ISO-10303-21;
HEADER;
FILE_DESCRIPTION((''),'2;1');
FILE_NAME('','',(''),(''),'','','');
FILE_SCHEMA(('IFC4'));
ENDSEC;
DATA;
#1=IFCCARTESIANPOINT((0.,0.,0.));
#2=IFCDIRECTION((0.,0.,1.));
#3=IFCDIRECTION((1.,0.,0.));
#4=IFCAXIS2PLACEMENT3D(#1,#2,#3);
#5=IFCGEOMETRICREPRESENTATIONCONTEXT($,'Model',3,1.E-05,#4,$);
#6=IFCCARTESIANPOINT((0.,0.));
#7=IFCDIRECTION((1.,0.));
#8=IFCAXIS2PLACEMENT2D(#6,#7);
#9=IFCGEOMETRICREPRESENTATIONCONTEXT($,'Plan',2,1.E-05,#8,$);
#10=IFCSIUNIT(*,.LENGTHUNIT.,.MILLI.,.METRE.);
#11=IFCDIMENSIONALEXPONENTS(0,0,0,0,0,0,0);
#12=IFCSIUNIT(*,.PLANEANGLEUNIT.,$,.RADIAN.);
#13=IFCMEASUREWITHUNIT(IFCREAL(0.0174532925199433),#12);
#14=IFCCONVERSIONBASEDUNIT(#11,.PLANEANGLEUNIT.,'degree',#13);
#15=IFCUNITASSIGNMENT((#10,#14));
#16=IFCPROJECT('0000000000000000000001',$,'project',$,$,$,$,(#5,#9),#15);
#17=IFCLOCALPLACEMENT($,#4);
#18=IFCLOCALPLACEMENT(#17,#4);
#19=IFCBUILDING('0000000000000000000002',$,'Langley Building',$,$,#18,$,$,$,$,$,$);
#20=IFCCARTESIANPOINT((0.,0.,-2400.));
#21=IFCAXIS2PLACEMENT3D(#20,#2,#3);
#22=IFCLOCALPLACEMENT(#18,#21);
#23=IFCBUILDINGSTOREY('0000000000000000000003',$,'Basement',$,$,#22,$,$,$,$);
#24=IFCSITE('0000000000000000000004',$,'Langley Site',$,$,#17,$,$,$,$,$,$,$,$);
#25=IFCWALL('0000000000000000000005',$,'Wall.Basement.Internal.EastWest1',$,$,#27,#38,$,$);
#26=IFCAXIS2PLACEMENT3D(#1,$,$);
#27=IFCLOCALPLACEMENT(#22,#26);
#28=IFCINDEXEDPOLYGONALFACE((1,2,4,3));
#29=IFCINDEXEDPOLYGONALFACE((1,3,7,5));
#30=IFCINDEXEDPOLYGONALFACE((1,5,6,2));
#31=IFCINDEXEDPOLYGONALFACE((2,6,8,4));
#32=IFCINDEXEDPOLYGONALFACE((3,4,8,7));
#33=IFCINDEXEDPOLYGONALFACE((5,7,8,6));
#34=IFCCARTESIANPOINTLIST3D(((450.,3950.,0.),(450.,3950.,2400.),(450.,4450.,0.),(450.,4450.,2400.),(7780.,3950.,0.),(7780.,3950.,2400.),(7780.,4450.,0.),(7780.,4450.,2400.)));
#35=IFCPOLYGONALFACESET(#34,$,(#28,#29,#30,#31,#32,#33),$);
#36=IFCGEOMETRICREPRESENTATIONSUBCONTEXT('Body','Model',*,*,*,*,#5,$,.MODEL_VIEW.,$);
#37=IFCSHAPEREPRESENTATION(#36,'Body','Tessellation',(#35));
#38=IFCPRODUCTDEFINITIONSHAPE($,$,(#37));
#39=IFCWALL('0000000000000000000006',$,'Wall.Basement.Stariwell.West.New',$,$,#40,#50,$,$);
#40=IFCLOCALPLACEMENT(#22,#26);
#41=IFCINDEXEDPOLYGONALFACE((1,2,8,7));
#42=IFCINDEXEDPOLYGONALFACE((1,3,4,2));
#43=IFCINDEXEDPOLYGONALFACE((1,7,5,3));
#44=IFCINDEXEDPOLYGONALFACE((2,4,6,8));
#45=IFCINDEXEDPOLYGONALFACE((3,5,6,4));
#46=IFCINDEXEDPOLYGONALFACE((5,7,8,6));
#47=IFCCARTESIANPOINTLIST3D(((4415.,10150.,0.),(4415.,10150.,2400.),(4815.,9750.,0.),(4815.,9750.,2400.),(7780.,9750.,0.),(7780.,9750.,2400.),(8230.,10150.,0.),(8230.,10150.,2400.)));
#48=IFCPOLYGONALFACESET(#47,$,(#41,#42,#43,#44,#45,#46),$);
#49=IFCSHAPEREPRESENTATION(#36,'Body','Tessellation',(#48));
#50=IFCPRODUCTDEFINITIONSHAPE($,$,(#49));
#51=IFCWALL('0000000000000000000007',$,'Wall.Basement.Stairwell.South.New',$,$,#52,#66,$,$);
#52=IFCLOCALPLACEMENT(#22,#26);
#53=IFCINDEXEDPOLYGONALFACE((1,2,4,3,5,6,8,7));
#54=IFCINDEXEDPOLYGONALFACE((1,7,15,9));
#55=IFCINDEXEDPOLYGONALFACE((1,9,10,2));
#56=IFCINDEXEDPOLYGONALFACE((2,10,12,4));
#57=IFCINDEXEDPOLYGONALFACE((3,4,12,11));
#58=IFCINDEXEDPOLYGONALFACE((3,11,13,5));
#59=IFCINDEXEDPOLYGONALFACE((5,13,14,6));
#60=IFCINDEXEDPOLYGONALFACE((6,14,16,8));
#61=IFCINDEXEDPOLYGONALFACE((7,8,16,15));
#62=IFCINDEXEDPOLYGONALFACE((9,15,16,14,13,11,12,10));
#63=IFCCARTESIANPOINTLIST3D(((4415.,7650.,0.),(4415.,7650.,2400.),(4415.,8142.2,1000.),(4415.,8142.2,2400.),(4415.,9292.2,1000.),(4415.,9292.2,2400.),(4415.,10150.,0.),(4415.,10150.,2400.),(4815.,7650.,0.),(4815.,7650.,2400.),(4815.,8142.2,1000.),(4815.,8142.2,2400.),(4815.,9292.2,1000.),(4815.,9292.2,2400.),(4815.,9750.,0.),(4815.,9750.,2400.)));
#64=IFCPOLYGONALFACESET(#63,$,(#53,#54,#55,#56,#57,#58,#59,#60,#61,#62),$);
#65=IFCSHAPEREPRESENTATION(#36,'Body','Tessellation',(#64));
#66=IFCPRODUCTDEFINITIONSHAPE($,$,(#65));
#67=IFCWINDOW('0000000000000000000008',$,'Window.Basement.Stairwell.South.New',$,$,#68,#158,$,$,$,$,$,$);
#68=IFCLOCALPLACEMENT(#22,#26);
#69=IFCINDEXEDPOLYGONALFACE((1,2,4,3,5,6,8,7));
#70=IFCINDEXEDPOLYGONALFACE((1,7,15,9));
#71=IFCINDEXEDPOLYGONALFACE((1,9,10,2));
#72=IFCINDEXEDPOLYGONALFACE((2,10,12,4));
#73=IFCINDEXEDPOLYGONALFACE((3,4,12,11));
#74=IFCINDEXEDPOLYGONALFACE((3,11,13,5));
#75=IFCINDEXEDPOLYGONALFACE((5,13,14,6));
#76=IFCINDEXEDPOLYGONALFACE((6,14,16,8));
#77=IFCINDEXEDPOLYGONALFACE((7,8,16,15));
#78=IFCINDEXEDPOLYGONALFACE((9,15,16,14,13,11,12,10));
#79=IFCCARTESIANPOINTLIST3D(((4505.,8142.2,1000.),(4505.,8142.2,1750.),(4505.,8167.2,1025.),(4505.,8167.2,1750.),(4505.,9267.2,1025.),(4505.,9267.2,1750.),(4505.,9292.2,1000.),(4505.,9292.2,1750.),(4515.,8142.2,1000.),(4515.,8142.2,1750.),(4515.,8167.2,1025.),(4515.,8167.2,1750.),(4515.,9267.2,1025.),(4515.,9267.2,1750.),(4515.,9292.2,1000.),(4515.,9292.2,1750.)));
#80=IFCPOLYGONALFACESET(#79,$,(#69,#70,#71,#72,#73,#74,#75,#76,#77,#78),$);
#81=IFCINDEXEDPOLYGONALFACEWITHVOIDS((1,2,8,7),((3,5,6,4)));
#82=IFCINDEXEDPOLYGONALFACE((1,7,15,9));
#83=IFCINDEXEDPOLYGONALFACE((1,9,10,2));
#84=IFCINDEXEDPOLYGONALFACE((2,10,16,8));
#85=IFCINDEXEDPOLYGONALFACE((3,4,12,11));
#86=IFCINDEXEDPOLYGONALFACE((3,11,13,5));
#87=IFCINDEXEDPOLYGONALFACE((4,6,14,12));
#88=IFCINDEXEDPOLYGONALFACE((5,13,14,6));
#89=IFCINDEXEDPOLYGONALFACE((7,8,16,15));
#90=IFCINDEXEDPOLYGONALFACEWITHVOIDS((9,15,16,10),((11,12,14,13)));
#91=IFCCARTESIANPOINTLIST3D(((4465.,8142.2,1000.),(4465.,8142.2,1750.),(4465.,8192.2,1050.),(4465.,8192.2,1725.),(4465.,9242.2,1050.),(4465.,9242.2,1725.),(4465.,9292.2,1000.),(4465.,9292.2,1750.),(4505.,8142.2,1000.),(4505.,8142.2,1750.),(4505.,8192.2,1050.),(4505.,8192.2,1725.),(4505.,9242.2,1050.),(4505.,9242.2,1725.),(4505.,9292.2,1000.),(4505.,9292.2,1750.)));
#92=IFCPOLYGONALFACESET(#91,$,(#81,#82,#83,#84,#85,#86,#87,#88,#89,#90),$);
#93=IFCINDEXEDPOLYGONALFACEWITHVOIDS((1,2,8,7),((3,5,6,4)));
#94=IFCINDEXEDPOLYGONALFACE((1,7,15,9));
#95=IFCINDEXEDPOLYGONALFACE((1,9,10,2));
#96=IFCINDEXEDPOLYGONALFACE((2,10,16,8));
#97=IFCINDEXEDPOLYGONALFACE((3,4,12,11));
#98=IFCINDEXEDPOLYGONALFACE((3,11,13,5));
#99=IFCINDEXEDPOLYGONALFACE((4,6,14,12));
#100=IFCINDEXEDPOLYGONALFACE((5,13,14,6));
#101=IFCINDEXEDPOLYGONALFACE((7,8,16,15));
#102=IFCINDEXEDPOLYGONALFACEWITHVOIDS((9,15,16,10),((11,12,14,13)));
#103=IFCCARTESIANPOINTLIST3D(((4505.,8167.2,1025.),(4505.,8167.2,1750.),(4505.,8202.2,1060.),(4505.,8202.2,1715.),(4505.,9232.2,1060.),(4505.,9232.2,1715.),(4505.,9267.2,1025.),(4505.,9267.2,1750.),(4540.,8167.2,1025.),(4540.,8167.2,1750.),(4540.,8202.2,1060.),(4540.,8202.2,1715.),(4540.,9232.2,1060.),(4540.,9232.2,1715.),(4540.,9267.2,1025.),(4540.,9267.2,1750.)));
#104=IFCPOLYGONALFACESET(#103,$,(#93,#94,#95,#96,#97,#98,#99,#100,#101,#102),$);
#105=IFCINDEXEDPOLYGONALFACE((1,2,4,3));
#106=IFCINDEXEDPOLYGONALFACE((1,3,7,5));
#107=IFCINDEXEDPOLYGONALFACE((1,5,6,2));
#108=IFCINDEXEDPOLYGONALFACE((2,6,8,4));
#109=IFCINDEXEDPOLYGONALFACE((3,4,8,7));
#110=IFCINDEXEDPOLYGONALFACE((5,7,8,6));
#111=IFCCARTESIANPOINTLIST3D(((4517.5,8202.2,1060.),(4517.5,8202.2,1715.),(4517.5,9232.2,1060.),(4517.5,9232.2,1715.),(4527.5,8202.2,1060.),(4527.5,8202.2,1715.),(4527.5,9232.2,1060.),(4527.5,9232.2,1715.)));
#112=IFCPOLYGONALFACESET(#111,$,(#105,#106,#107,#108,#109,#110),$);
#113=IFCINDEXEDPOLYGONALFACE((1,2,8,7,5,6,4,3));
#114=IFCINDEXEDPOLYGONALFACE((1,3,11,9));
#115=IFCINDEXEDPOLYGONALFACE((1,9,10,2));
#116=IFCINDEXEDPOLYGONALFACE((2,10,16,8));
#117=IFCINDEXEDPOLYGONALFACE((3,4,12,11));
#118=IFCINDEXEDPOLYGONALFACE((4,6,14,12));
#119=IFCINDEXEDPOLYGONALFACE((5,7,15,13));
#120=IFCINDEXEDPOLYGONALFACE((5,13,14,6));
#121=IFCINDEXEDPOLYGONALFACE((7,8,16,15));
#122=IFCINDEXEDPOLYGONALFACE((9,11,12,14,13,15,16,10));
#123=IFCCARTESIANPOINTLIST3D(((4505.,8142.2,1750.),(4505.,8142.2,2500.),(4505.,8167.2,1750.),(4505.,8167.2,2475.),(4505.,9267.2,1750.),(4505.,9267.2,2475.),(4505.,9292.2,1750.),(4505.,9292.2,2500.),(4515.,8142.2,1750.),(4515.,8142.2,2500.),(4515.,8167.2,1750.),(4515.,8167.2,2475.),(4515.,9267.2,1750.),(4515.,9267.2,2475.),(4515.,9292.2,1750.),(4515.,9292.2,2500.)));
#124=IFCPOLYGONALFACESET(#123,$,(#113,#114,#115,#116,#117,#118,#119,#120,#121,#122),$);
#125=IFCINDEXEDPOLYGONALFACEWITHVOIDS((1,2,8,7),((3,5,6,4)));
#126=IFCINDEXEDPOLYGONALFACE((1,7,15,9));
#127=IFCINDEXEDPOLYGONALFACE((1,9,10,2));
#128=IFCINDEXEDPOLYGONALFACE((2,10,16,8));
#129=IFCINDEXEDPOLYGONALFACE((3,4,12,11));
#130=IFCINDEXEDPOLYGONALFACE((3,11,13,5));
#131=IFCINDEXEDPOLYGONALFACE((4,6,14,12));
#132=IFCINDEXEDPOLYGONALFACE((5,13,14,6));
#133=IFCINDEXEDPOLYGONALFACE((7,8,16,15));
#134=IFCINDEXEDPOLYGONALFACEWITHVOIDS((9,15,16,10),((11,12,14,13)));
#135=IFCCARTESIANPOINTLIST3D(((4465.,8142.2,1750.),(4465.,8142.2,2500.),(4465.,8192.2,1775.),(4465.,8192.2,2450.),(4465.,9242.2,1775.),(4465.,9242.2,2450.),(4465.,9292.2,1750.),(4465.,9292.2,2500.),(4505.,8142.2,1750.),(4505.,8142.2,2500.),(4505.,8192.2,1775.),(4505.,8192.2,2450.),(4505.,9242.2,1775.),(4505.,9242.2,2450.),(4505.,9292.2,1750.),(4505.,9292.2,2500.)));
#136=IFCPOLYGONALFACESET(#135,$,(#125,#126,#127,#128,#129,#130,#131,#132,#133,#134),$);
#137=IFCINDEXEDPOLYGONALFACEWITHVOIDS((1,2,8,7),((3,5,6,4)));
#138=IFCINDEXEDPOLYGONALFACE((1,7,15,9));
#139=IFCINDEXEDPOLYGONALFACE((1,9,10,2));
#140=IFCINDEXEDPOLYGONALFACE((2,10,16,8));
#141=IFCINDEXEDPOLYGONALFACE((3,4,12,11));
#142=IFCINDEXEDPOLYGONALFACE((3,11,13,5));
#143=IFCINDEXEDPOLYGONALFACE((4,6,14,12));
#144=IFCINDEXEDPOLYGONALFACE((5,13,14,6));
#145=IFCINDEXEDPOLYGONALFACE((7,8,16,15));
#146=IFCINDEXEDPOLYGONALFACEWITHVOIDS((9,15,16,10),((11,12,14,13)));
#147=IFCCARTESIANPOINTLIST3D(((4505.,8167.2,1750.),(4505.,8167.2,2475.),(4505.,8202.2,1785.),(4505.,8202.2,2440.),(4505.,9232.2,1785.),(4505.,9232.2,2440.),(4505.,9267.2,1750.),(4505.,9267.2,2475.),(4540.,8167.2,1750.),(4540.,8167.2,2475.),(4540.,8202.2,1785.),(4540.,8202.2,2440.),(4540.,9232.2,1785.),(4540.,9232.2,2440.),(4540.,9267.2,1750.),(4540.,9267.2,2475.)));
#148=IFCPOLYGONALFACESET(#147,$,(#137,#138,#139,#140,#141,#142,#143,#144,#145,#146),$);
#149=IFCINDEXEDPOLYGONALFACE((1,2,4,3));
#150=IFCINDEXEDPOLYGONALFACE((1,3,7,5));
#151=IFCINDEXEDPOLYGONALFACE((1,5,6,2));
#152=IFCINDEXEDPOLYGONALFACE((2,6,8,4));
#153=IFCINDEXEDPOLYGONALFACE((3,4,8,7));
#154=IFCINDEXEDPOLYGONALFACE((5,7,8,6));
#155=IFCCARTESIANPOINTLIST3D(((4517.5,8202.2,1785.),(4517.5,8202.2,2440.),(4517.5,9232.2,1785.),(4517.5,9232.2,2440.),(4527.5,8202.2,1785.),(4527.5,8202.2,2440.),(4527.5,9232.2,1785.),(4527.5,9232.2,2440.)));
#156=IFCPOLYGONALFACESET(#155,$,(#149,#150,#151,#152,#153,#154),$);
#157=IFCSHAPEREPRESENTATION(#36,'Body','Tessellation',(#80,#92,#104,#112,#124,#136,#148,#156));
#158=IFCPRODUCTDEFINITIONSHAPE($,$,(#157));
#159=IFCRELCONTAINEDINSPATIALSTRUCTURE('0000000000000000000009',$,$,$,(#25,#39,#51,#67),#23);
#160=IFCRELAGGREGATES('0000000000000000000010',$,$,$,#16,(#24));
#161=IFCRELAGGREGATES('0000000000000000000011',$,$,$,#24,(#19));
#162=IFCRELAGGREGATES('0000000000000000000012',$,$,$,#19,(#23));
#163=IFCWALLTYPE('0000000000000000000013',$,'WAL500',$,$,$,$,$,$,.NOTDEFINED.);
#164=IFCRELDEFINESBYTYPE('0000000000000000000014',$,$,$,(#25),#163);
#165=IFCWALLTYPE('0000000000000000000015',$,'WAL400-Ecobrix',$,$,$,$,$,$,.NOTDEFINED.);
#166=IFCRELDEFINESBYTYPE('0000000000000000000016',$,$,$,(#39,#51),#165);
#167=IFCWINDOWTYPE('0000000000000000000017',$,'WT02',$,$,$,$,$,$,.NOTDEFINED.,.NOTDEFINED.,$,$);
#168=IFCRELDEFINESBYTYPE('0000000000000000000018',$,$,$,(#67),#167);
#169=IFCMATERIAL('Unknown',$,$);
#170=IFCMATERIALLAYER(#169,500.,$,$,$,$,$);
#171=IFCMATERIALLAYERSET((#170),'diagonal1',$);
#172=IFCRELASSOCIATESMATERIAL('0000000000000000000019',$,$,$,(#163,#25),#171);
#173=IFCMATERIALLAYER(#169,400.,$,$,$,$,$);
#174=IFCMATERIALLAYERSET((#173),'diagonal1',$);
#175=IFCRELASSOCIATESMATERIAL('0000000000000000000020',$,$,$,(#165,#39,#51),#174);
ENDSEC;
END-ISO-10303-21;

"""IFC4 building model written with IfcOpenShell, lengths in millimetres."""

from ifc_helpers import new_model, entity, si_unit, converted_unit, frame, origin_with_axes, origin_2d_with_axis, place, context, subcontext, project, spatial, line, indexed_curve, outline, extrude, shape, source, transform, mapped, material, layer, layer_set, layer_usage, type_object, type_shapes, element, fill, save


model = new_model("IFC4")

# Units and contexts
model_context = context("Model", 3, precision=1e-05, world=origin_with_axes())
plan_context = context("Plan", 2, precision=1e-05, world=origin_2d_with_axis())
body_context_1 = subcontext(model_context, "Body", "Model", "MODEL_VIEW")
body_context_2 = subcontext(plan_context, "Body", "Plan", "PLAN_VIEW")
ifc_project = project(units=[si_unit("LENGTHUNIT", "METRE", prefix="MILLI"), converted_unit("PLANEANGLEUNIT", "degree", entity("IfcReal", 0.0174532925199433), si_unit("PLANEANGLEUNIT", "RADIAN"), dimensions=[0, 0, 0, 0, 0, 0, 0])], contexts=[model_context, plan_context])

# Site, building, storey
site_placement = place(None, origin_with_axes())
site = spatial("IfcSite", under=ifc_project, at=site_placement, Name="Langley Site")
building_placement = place(site_placement, origin_with_axes())
building = spatial("IfcBuilding", under=site, at=building_placement, Name="Langley Building")
storey_placement = place(building_placement, frame((0.0, 0.0, -2400.0), z_axis=(0.0, 0.0, 1.0), x_axis=(1.0, 0.0, 0.0)))
storey = spatial("IfcBuildingStorey", under=building, at=storey_placement, Name="Basement")

# Shared definitions
ifc_material = material(Name="Unknown")

# Walls
ifc_layer_1 = layer(ifc_material, 500.0)
ifc_layer_set_1 = layer_set([ifc_layer_1], Name="diagonal1")
ifc_layer_usage_1 = layer_usage(ifc_layer_set_1, "AXIS2", "POSITIVE", 0.0)
wall_type_1 = type_object("IfcWallType", Name="WAL500", PredefinedType="NOTDEFINED", material=ifc_layer_set_1)
wall_1_placement = place(storey_placement, frame((450.0, 3950.0, 0.0), z_axis=(0.0, 0.0, 1.0), x_axis=(1.0, 0.0, 0.0)))
element("IfcWall", 1, at=wall_1_placement, inside=storey, type_object=wall_type_1, material=ifc_layer_usage_1, Name="Wall.Basement.Internal.EastWest1", context=body_context_1, shape_type="SweptSolid", body=[
    extrude(outline(indexed_curve([(0.0, 0.0), (0.0, 500.0), (7330.0, 500.0), (7330.0, 0.0)], segments=[line(1, 2, 3, 4, 1)])), origin_with_axes(), (0.0, 0.0, 1.0), 2400.0),
])
ifc_layer_2 = layer(ifc_material, 400.0)
ifc_layer_set_2 = layer_set([ifc_layer_2], Name="diagonal1")
ifc_layer_usage_2 = layer_usage(ifc_layer_set_2, "AXIS2", "POSITIVE", 0.0)
wall_type_2 = type_object("IfcWallType", Name="WAL400-Ecobrix", PredefinedType="NOTDEFINED", material=ifc_layer_set_2)
wall_2_placement = place(storey_placement, frame((8230.0, 10150.0, 0.0), z_axis=(0.0, 0.0, 1.0), x_axis=(-1.0, 0.0, 0.0)))
element("IfcWall", 2, at=wall_2_placement, inside=storey, type_object=wall_type_2, material=ifc_layer_usage_2, Name="Wall.Basement.Stariwell.West.New", context=body_context_1, shape_type="SweptSolid", body=[
    extrude(outline(indexed_curve([(0.0, 0.0), (450.0, 400.0), (3415.0, 400.0), (3815.0, 0.0)], segments=[line(1, 2, 3, 4, 1)])), origin_with_axes(), (0.0, 0.0, 1.0), 2400.0),
])

# Wall, opening, window
ifc_layer_usage_3 = layer_usage(ifc_layer_set_2, "AXIS2", "POSITIVE", 0.0)
wall_3_placement = place(storey_placement, frame((4415.0, 10150.0, 0.0), z_axis=(0.0, 0.0, 1.0), x_axis=(0.0, -1.0, 0.0)))
wall_3 = element("IfcWall", 3, at=wall_3_placement, inside=storey, type_object=wall_type_2, material=ifc_layer_usage_3, Name="Wall.Basement.Stairwell.South.New", context=body_context_1, shape_type="SweptSolid", body=[
    extrude(outline(indexed_curve([(0.0, 0.0), (400.0, 400.0), (2500.0, 400.0), (2500.0, 0.0)], segments=[line(1, 2, 3, 4, 1)])), origin_with_axes(), (0.0, 0.0, 1.0), 2400.0),
])
shared_shape_1 = source(origin_with_axes(), body_context_1, "Body", "SweptSolid", [
    extrude(outline(indexed_curve([(0.0, 0.0), (1150.0, 0.0), (1150.0, 1500.0), (0.0, 1500.0)], segments=[line(1, 2, 3, 4, 1)])), frame((0.0, -600.0, 0.0), z_axis=(0.0, -1.0, 0.0), x_axis=(1.0, 0.0, 0.0)), (0.0, 0.0, -1.0), 1200.0),
])
opening_1_placement = place(wall_3_placement, frame((857.8, 0.0, 1000.0), z_axis=(0.0, 0.0, 1.0), x_axis=(1.0, 0.0, 0.0)))
opening_1 = element("IfcOpeningElement", 4, at=opening_1_placement, cuts=wall_3, PredefinedType="OPENING", context=body_context_1, shape_type="MappedRepresentation", body=[
    mapped(shared_shape_1, transform((0.0, 0.0, 0.0), x_axis=(1.0, 0.0, 0.0), y_axis=(0.0, 1.0, 0.0), z_axis=(0.0, 0.0, 1.0), scale=1.0)),
])
window_type_1 = type_object("IfcWindowType", Name="WT02", PartitioningType="NOTDEFINED", PredefinedType="NOTDEFINED")
shared_shape_2 = source(origin_with_axes(), body_context_1, "Body", "SweptSolid", [
    extrude(outline(indexed_curve([(1150.0, 750.0), (1150.0, 0.0), (0.0, 0.0), (0.0, 750.0), (25.0, 750.0), (25.0, 25.0), (1125.0, 25.0), (1125.0, 750.0)], segments=[line(1, 2, 3, 4, 5, 6, 7, 8, 1)])), frame((0.0, 90.0, 0.0), z_axis=(0.0, -1.0, 0.0), x_axis=(1.0, 0.0, 0.0)), (0.0, 0.0, -1.0), 10.0),
    extrude(outline(indexed_curve([(0.0, 0.0), (1150.0, 0.0), (1150.0, 750.0), (0.0, 750.0)], segments=[line(1, 2, 3, 4, 1)]), holes=[indexed_curve([(50.0, 50.0), (1100.0, 50.0), (1100.0, 725.0), (50.0, 725.0)], segments=[line(1, 2, 3, 4, 1)])]), frame((0.0, 50.0, 0.0), z_axis=(0.0, -1.0, 0.0), x_axis=(1.0, 0.0, 0.0)), (0.0, 0.0, -1.0), 40.0),
    extrude(outline(indexed_curve([(0.0, 0.0), (1100.0, 0.0), (1100.0, 725.0), (0.0, 725.0)], segments=[line(1, 2, 3, 4, 1)]), holes=[indexed_curve([(35.0, 35.0), (1065.0, 35.0), (1065.0, 690.0), (35.0, 690.0)], segments=[line(1, 2, 3, 4, 1)])]), frame((25.0, 90.0, 25.0), z_axis=(0.0, -1.0, 0.0), x_axis=(1.0, 0.0, 0.0)), (0.0, 0.0, -1.0), 35.0),
    extrude(outline(indexed_curve([(35.0, 35.0), (1065.0, 35.0), (1065.0, 690.0), (35.0, 690.0)], segments=[line(1, 2, 3, 4, 1)])), frame((25.0, 102.5, 25.0), z_axis=(0.0, -1.0, 0.0), x_axis=(1.0, 0.0, 0.0)), (0.0, 0.0, -1.0), 10.0),
    extrude(outline(indexed_curve([(0.0, 0.0), (0.0, 750.0), (1150.0, 750.0), (1150.0, 0.0), (1125.0, 0.0), (1125.0, 725.0), (25.0, 725.0), (25.0, 0.0)], segments=[line(1, 2, 3, 4, 5, 6, 7, 8, 1)])), frame((0.0, 90.0, 750.0), z_axis=(0.0, -1.0, 0.0), x_axis=(1.0, 0.0, 0.0)), (0.0, 0.0, -1.0), 10.0),
    extrude(outline(indexed_curve([(0.0, 0.0), (1150.0, 0.0), (1150.0, 750.0), (0.0, 750.0)], segments=[line(1, 2, 3, 4, 1)]), holes=[indexed_curve([(50.0, 25.0), (1100.0, 25.0), (1100.0, 700.0), (50.0, 700.0)], segments=[line(1, 2, 3, 4, 1)])]), frame((0.0, 50.0, 750.0), z_axis=(0.0, -1.0, 0.0), x_axis=(1.0, 0.0, 0.0)), (0.0, 0.0, -1.0), 40.0),
    extrude(outline(indexed_curve([(0.0, 0.0), (1100.0, 0.0), (1100.0, 725.0), (0.0, 725.0)], segments=[line(1, 2, 3, 4, 1)]), holes=[indexed_curve([(35.0, 35.0), (1065.0, 35.0), (1065.0, 690.0), (35.0, 690.0)], segments=[line(1, 2, 3, 4, 1)])]), frame((25.0, 90.0, 750.0), z_axis=(0.0, -1.0, 0.0), x_axis=(1.0, 0.0, 0.0)), (0.0, 0.0, -1.0), 35.0),
    extrude(outline(indexed_curve([(35.0, 35.0), (1065.0, 35.0), (1065.0, 690.0), (35.0, 690.0)], segments=[line(1, 2, 3, 4, 1)])), frame((25.0, 102.5, 750.0), z_axis=(0.0, -1.0, 0.0), x_axis=(1.0, 0.0, 0.0)), (0.0, 0.0, -1.0), 10.0),
])
shared_shape_3 = source(origin_with_axes(), body_context_2, "Body", "Curve2D", [
    entity("IfcIndexedPolyCurve", entity("IfcCartesianPointList2D", [[50.0, 50.0], [1100.0, 50.0]])),
    entity("IfcIndexedPolyCurve", entity("IfcCartesianPointList2D", [[0.0, 100.0], [25.0, 100.0], [25.0, 90.0], [50.0, 90.0], [50.0, 50.0], [0.0, 50.0]]), [entity("IfcLineIndex", [1, 2, 3, 4, 5, 6, 1])]),
    entity("IfcIndexedPolyCurve", entity("IfcCartesianPointList2D", [[1150.0, 100.0], [1125.0, 100.0], [1125.0, 90.0], [1100.0, 90.0], [1100.0, 50.0], [1150.0, 50.0]]), [entity("IfcLineIndex", [1, 2, 3, 4, 5, 6, 1])]),
    entity("IfcIndexedPolyCurve", entity("IfcCartesianPointList2D", [[25.0, 90.0], [60.0, 90.0], [60.0, 125.0], [25.0, 125.0]]), [entity("IfcLineIndex", [1, 2, 3, 4, 1])]),
    entity("IfcIndexedPolyCurve", entity("IfcCartesianPointList2D", [[1125.0, 90.0], [1090.0, 90.0], [1090.0, 125.0], [1125.0, 125.0]]), [entity("IfcLineIndex", [1, 2, 3, 4, 1])]),
    entity("IfcIndexedPolyCurve", entity("IfcCartesianPointList2D", [[60.0, 90.0], [1090.0, 90.0]])),
    entity("IfcIndexedPolyCurve", entity("IfcCartesianPointList2D", [[60.0, 125.0], [1090.0, 125.0]])),
    entity("IfcIndexedPolyCurve", entity("IfcCartesianPointList2D", [[60.0, 107.5], [1090.0, 107.5]])),
])
type_shapes(window_type_1, [shared_shape_2, shared_shape_3])
window_1_placement = place(opening_1_placement, frame((0.0, 0.0, 0.0), z_axis=(0.0, 0.0, 1.0), x_axis=(1.0, 0.0, 0.0)))
window_1 = element("IfcWindow", 5, at=window_1_placement, inside=storey, type_object=window_type_1, Name="Window.Basement.Stairwell.South.New", shapes=[
    shape(body_context_1, "Body", "MappedRepresentation", [mapped(shared_shape_2, transform((0.0, 0.0, 0.0), x_axis=(1.0, 0.0, 0.0), y_axis=(0.0, 1.0, 0.0), z_axis=(0.0, 0.0, 1.0), scale=1.0))]),
    shape(body_context_2, "Body", "MappedRepresentation", [mapped(shared_shape_3, transform((0.0, 0.0, 0.0), x_axis=(1.0, 0.0, 0.0), y_axis=(0.0, 1.0, 0.0), z_axis=(0.0, 0.0, 1.0), scale=1.0))]),
])
fill(opening_1, window_1)

save(model, "model.ifc")
